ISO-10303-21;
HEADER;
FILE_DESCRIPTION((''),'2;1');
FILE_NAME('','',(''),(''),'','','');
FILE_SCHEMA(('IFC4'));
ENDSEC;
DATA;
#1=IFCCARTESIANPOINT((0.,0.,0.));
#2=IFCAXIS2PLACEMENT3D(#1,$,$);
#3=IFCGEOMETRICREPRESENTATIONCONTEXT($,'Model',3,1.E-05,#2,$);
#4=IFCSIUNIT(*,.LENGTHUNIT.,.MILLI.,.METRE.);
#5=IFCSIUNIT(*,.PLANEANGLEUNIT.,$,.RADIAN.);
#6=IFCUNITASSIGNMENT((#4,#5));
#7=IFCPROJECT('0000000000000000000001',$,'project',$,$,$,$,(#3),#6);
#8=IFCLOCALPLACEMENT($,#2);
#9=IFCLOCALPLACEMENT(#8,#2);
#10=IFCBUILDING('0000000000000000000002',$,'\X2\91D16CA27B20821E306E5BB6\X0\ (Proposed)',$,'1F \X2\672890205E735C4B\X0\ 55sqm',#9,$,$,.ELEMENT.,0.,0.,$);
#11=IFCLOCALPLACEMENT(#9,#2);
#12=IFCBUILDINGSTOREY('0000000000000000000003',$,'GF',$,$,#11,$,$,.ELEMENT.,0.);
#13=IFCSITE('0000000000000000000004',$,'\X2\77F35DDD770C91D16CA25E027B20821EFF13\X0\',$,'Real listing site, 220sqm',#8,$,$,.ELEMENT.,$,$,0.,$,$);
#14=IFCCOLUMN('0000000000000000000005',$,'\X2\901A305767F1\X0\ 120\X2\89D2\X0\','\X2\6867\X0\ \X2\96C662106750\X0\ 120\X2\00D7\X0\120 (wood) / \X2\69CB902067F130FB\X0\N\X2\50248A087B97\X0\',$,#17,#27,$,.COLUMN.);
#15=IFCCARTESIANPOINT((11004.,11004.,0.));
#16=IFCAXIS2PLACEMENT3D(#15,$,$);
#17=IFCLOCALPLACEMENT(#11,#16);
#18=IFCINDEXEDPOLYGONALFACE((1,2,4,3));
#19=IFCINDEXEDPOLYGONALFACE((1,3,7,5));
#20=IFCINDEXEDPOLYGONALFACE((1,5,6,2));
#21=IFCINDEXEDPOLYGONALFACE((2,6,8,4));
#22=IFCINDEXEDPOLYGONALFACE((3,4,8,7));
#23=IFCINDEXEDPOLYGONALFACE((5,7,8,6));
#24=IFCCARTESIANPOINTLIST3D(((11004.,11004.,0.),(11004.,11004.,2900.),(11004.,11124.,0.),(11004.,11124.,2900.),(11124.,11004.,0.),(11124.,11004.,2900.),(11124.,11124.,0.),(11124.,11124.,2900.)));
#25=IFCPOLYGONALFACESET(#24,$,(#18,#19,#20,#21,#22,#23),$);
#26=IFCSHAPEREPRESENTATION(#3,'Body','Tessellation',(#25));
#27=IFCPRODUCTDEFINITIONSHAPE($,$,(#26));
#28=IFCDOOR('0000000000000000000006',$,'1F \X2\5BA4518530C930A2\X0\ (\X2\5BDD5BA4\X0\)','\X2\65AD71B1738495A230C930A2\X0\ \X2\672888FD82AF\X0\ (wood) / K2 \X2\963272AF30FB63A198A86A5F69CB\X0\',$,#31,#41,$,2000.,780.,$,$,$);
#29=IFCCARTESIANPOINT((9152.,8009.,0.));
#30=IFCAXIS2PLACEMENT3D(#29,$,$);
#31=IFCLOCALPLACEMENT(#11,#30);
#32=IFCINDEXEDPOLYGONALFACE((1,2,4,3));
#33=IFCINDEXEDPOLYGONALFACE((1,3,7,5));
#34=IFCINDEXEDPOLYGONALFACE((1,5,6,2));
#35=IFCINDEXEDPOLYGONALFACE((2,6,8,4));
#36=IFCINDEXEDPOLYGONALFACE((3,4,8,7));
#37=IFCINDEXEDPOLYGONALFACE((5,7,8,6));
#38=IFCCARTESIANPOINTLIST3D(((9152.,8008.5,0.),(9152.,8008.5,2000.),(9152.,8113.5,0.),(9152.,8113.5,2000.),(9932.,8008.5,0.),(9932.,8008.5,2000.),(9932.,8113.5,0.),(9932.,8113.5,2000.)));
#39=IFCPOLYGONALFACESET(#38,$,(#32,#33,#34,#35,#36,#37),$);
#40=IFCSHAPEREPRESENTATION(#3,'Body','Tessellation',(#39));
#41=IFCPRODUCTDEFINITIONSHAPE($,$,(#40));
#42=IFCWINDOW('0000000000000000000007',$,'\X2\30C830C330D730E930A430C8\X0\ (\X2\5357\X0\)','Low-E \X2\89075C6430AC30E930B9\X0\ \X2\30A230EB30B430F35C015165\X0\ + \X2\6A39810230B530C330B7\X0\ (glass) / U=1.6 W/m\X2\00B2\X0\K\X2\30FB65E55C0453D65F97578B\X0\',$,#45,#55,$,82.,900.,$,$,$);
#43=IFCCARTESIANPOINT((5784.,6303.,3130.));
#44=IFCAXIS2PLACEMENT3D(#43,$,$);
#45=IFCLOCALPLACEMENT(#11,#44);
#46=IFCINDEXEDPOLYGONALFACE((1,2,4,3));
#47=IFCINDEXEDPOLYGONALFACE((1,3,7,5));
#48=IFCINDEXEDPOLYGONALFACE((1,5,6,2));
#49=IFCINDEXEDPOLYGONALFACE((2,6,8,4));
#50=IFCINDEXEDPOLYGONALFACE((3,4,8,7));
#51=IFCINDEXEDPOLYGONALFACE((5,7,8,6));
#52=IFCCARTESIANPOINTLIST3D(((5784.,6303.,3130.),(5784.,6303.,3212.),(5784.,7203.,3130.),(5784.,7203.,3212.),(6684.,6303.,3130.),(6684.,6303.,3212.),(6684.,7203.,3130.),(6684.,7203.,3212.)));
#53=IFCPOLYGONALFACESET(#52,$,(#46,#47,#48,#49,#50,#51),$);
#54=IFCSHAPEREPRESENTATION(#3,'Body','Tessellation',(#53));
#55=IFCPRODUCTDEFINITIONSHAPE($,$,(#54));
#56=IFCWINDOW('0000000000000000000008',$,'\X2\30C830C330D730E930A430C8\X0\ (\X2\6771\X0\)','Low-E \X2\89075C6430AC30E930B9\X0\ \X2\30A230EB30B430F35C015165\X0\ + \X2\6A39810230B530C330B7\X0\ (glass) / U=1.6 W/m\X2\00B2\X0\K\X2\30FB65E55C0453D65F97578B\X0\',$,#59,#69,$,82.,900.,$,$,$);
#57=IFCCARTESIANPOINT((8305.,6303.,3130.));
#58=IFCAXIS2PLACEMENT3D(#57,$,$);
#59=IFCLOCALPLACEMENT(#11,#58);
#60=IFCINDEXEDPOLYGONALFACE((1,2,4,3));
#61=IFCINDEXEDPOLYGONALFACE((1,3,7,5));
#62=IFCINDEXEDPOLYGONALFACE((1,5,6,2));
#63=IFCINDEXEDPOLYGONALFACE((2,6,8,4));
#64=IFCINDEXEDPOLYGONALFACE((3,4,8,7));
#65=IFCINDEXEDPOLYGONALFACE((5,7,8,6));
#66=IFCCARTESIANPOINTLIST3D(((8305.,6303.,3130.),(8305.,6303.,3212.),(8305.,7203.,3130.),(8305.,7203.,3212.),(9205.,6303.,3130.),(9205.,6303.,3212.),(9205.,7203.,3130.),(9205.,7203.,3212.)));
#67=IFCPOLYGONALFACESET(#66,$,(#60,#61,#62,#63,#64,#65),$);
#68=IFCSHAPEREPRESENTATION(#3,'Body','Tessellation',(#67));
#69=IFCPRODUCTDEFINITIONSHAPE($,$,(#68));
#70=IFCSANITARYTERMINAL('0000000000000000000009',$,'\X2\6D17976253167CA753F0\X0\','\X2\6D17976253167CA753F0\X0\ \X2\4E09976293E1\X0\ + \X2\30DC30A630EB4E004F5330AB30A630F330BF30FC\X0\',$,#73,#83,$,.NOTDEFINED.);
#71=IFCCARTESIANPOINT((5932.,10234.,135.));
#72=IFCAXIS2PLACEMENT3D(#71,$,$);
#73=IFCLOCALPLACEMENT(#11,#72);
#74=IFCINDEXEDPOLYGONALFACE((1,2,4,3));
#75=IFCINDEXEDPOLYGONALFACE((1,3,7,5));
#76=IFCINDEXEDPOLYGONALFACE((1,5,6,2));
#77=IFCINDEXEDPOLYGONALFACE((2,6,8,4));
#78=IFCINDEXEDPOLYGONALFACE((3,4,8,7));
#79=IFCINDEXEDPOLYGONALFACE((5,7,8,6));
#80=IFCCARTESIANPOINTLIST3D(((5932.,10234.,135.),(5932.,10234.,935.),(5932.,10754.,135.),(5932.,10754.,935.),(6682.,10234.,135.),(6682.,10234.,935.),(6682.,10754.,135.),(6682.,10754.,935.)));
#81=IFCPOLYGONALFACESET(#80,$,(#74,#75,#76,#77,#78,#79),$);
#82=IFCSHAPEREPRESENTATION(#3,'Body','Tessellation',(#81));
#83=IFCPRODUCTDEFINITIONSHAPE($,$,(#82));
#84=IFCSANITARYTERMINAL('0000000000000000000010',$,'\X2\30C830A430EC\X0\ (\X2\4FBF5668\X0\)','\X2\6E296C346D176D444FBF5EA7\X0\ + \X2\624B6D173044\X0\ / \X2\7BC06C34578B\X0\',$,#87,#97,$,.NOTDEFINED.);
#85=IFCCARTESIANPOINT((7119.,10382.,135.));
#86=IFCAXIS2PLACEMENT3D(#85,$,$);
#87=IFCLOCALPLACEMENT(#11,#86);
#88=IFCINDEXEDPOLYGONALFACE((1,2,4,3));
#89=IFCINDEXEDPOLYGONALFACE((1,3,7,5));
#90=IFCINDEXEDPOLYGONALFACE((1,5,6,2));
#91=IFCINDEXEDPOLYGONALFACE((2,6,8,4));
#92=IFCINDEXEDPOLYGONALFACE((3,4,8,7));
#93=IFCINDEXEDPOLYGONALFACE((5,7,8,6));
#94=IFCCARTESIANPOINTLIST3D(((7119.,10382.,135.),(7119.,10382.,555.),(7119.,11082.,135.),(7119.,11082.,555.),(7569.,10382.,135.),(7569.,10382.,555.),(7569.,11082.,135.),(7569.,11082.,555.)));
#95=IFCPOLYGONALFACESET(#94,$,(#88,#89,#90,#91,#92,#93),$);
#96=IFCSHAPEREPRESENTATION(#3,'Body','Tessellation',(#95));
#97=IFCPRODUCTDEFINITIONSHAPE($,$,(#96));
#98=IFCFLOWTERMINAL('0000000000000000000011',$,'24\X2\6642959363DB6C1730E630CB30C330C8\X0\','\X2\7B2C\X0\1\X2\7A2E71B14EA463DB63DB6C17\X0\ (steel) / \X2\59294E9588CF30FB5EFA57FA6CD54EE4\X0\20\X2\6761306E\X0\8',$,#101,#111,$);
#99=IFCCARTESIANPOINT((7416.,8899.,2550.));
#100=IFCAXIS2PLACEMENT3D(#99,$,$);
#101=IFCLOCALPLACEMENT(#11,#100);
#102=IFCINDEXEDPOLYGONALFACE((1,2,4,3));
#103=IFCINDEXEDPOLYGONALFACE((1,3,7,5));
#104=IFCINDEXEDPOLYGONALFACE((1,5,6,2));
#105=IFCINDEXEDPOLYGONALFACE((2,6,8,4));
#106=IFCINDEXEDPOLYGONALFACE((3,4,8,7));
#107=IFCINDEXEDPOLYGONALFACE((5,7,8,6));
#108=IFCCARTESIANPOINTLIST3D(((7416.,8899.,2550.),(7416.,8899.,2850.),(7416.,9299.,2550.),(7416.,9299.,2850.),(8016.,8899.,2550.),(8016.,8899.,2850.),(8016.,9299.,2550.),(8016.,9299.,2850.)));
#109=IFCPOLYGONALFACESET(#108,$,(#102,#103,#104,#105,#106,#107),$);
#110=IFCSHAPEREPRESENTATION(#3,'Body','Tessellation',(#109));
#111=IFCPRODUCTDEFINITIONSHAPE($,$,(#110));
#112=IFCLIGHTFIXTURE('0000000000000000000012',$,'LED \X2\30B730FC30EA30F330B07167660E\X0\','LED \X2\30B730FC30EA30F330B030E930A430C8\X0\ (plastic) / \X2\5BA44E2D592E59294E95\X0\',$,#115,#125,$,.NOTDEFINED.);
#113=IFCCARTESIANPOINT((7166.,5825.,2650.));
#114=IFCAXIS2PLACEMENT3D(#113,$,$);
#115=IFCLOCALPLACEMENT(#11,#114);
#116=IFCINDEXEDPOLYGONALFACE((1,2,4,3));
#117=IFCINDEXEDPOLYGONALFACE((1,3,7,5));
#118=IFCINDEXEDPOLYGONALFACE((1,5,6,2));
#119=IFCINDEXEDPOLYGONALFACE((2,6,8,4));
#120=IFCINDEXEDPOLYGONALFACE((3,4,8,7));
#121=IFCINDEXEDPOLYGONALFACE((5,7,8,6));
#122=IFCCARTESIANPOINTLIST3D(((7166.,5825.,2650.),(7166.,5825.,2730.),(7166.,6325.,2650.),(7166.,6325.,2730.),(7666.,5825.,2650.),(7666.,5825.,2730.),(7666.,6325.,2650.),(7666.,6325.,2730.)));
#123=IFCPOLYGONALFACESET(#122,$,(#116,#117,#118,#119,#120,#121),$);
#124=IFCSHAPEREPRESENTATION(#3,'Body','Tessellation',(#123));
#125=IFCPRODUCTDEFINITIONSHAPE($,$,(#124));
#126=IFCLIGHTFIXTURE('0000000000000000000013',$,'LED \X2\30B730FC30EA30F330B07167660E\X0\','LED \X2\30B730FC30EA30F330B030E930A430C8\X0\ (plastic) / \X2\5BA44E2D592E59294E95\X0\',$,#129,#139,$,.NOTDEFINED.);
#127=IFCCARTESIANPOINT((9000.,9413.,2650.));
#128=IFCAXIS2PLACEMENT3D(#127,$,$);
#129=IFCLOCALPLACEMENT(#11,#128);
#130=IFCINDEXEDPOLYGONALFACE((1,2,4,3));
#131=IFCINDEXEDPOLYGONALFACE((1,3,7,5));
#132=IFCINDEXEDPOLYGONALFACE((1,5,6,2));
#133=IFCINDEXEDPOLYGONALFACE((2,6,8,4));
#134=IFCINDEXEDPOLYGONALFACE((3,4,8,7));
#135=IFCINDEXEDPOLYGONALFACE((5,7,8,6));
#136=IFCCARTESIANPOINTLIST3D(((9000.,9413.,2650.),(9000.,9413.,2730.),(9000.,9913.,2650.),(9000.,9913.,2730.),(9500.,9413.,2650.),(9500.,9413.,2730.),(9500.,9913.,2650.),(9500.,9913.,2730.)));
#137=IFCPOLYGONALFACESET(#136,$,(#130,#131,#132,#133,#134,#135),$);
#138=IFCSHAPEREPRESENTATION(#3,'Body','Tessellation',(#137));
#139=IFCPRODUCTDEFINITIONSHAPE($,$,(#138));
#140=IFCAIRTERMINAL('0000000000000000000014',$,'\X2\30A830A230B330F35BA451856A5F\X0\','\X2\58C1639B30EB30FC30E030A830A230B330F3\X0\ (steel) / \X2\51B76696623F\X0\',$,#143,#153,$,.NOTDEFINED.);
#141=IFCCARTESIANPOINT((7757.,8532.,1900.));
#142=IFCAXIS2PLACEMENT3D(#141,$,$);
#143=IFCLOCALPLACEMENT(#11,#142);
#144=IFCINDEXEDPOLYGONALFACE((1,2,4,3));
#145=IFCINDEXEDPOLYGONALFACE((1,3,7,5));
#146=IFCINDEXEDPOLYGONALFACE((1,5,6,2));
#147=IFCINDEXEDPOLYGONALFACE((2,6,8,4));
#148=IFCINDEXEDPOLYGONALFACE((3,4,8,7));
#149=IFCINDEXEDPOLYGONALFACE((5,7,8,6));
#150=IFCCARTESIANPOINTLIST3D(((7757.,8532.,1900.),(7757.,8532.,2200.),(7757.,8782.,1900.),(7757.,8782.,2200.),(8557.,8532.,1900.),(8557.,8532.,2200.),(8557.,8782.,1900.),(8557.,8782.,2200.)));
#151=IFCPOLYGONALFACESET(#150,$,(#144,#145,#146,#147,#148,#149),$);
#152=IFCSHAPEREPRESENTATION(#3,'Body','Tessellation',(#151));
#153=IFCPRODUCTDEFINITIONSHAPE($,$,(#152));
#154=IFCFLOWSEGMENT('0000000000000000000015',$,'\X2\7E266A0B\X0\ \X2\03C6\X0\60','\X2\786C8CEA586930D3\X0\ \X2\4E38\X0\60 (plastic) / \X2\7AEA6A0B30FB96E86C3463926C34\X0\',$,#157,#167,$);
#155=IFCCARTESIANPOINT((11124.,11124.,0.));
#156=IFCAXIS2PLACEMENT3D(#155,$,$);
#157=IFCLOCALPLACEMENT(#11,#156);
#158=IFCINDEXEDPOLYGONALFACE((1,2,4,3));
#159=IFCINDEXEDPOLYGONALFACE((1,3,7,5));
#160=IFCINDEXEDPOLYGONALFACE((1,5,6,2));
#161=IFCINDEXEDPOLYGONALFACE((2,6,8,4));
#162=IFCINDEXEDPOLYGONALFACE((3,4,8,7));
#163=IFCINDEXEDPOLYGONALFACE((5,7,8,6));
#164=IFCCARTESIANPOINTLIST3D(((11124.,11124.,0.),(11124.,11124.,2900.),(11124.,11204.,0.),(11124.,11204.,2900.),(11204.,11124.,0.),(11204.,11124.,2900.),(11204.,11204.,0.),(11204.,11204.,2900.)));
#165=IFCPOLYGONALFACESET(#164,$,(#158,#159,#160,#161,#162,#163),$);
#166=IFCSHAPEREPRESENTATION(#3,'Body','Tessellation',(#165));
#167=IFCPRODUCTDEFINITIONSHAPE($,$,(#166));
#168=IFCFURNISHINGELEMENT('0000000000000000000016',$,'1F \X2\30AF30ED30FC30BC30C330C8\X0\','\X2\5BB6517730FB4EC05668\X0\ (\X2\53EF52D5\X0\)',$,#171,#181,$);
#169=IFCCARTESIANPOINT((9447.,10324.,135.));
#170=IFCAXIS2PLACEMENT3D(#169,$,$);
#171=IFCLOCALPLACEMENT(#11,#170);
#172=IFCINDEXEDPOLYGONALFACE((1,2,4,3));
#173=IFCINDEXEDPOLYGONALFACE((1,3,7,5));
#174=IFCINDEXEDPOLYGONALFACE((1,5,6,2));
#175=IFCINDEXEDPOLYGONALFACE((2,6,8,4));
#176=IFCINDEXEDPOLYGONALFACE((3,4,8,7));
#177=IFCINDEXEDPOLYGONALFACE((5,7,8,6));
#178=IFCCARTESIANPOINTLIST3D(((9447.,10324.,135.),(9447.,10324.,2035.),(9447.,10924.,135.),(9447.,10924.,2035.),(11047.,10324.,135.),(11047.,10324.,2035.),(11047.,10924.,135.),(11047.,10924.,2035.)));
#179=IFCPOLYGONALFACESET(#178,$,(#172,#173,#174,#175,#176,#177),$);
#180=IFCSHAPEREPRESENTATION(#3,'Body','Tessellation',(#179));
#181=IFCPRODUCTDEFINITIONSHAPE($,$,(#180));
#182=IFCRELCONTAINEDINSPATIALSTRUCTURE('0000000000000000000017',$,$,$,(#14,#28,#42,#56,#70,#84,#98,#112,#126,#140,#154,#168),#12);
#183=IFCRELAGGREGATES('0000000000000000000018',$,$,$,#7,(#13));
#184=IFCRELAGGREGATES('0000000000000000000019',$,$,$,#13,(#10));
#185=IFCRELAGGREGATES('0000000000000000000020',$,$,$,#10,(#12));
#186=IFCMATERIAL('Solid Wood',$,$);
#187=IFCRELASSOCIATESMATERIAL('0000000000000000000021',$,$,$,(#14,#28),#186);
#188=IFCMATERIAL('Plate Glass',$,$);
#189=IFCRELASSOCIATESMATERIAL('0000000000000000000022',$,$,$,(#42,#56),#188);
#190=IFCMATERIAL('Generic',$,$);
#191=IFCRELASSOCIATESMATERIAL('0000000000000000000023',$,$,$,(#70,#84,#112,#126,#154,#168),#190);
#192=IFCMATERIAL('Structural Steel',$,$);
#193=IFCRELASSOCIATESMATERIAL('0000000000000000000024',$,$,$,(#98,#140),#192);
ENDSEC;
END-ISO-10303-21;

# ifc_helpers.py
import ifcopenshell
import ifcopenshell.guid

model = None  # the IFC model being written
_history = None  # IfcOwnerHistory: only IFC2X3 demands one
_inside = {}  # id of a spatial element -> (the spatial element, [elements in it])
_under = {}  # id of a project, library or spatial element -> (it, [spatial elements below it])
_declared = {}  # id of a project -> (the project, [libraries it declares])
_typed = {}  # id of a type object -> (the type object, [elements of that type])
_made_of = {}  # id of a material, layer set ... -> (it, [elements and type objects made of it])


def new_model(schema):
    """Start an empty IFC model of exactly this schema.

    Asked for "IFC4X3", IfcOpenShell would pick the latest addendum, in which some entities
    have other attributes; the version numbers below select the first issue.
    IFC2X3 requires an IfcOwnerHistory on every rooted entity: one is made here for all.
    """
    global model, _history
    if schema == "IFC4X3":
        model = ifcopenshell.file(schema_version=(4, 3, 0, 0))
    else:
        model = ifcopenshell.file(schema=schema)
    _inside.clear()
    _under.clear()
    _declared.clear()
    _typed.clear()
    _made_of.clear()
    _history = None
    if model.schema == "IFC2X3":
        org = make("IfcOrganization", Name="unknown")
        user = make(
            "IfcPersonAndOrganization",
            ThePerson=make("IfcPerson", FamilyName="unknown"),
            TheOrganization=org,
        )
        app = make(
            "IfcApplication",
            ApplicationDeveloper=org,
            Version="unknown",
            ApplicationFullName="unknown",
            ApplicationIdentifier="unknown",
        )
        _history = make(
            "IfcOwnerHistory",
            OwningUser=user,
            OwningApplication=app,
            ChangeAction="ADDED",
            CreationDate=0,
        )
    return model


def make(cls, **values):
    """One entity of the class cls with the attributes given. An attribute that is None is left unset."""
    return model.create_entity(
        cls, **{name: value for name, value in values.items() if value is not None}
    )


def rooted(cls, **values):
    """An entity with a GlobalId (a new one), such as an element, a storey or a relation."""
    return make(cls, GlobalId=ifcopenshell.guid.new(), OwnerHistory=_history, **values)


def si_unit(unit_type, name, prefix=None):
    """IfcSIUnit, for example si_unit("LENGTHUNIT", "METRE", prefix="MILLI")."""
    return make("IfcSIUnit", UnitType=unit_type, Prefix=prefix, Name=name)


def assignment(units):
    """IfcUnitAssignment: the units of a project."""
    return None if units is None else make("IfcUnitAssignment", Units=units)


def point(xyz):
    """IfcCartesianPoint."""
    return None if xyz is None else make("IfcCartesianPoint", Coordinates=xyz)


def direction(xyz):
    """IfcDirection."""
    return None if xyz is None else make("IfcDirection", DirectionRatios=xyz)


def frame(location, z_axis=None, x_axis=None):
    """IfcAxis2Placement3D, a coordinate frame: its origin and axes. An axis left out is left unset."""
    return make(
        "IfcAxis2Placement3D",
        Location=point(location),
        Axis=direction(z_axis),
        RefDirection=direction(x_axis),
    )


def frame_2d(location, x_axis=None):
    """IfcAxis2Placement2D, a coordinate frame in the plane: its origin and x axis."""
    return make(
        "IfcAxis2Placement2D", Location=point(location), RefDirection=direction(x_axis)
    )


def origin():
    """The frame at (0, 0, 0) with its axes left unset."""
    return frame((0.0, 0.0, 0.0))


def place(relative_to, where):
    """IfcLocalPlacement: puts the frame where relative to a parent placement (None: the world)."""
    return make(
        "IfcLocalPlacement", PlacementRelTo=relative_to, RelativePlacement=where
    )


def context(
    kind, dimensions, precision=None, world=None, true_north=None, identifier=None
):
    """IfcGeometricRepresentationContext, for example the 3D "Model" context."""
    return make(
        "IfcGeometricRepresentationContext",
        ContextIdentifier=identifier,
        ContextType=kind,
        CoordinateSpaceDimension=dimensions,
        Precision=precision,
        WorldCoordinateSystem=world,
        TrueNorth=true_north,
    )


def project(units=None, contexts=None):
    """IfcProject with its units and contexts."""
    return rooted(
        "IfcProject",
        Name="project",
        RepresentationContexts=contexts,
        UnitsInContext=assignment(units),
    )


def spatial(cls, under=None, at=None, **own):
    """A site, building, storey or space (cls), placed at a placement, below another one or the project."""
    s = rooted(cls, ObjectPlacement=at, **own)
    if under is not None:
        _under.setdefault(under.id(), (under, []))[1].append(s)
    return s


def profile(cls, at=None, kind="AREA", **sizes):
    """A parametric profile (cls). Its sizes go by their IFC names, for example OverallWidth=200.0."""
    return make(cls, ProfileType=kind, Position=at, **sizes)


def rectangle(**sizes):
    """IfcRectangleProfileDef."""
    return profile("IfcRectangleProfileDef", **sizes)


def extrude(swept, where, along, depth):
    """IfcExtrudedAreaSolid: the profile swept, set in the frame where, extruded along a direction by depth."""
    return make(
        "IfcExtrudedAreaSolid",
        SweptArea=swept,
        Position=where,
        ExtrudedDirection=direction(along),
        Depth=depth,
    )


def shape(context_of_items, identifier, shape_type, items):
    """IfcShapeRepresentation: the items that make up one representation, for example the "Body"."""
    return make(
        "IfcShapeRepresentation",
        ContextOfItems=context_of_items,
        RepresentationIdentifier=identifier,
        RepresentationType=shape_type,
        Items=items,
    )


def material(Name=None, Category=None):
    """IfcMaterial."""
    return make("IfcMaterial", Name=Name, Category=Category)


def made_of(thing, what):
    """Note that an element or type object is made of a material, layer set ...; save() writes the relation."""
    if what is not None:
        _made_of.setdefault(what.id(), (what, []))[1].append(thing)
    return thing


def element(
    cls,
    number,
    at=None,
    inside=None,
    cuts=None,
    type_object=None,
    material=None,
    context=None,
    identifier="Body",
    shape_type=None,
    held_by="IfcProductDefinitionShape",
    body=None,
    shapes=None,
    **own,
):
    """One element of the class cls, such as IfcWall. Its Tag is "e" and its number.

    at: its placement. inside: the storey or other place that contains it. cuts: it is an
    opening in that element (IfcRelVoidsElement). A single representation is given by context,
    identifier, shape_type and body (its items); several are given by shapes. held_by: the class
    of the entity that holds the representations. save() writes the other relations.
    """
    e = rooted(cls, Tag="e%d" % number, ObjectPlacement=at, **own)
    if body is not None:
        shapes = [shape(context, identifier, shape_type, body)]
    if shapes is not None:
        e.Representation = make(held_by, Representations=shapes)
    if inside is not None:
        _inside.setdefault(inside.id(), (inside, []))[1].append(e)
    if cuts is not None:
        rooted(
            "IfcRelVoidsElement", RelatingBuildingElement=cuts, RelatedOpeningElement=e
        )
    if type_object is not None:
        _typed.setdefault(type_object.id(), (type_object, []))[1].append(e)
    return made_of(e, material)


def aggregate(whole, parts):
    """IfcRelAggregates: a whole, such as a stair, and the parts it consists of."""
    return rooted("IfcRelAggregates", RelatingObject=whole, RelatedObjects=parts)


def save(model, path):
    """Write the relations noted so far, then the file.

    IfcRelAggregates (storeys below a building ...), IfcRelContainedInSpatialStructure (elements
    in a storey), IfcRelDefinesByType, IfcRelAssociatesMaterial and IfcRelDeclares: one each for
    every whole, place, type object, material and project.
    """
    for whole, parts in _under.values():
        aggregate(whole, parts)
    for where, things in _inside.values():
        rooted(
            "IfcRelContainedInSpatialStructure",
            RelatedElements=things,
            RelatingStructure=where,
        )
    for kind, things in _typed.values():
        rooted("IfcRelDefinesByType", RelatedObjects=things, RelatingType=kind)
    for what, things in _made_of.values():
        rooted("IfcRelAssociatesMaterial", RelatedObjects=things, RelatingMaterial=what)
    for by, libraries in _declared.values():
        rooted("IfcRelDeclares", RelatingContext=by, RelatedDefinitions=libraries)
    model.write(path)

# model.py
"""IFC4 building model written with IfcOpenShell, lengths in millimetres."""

from ifc_helpers import new_model, si_unit, frame, frame_2d, origin, place, context, project, spatial, rectangle, extrude, material, element, save


model = new_model("IFC4")

# Units and contexts
model_context = context("Model", 3, precision=1e-05, world=origin())
ifc_project = project(units=[si_unit("LENGTHUNIT", "METRE", prefix="MILLI"), si_unit("PLANEANGLEUNIT", "RADIAN")], contexts=[model_context])

# Site, building, storey
site_placement = place(None, origin())
site = spatial("IfcSite", under=ifc_project, at=site_placement, Name="石川県金沢市笠舞３", ObjectType="Real listing site, 220sqm", CompositionType="ELEMENT", RefElevation=0.0)
building_placement = place(site_placement, origin())
building = spatial("IfcBuilding", under=site, at=building_placement, Name="金沢笠舞の家 (Proposed)", ObjectType="1F 木造平屋 55sqm", CompositionType="ELEMENT", ElevationOfRefHeight=0.0, ElevationOfTerrain=0.0)
storey_placement = place(building_placement, origin())
storey = spatial("IfcBuildingStorey", under=building, at=storey_placement, Name="GF", CompositionType="ELEMENT", Elevation=0.0)

# Column
ifc_material_1 = material(Name="Solid Wood")
column_1_placement = place(storey_placement, frame((11004.0, 11004.0, 0.0)))
element("IfcColumn", 1, at=column_1_placement, inside=storey, material=ifc_material_1, Name="通し柱 120角", Description="桧 集成材 120×120 (wood) / 構造柱・N値計算", PredefinedType="COLUMN", context=model_context, shape_type="SweptSolid", body=[
    extrude(rectangle(XDim=120.0, YDim=120.0, at=frame_2d((60.0, 60.0))), frame((11004.0, 11004.0, 0.0)), (0.0, 0.0, 1.0), 2900.0),
])

# Door
door_placement = place(storey_placement, frame((9152.0, 8009.0, 0.0)))
element("IfcDoor", 2, at=door_placement, inside=storey, material=ifc_material_1, Name="1F 室内ドア (寝室)", Description="断熱玄関ドア 木製芯 (wood) / K2 防犯・採風機構", OverallHeight=2000.0, OverallWidth=780.0, context=model_context, shape_type="SweptSolid", body=[
    extrude(rectangle(XDim=780.0, YDim=105.0, at=frame_2d((390.0, 52.0))), frame((9152.0, 8009.0, 0.0)), (0.0, 0.0, 1.0), 2000.0),
])

# Windows
ifc_material_2 = material(Name="Plate Glass")
window_1_placement = place(storey_placement, frame((5784.0, 6303.0, 3130.0)))
element("IfcWindow", 3, at=window_1_placement, inside=storey, material=ifc_material_2, Name="トップライト (南)", Description="Low-E 複層ガラス アルゴン封入 + 樹脂サッシ (glass) / U=1.6 W/m²K・日射取得型", OverallHeight=82.0, OverallWidth=900.0, context=model_context, shape_type="SweptSolid", body=[
    extrude(rectangle(XDim=900.0, YDim=900.0, at=frame_2d((450.0, 450.0))), frame((5784.0, 6303.0, 3130.0)), (0.0, 0.0, 1.0), 82.0),
])
window_2_placement = place(storey_placement, frame((8305.0, 6303.0, 3130.0)))
element("IfcWindow", 4, at=window_2_placement, inside=storey, material=ifc_material_2, Name="トップライト (東)", Description="Low-E 複層ガラス アルゴン封入 + 樹脂サッシ (glass) / U=1.6 W/m²K・日射取得型", OverallHeight=82.0, OverallWidth=900.0, context=model_context, shape_type="SweptSolid", body=[
    extrude(rectangle(XDim=900.0, YDim=900.0, at=frame_2d((450.0, 450.0))), frame((8305.0, 6303.0, 3130.0)), (0.0, 0.0, 1.0), 82.0),
])

# Sanitary terminals
ifc_material_3 = material(Name="Generic")
sanitary_terminal_1_placement = place(storey_placement, frame((5932.0, 10234.0, 135.0)))
element("IfcSanitaryTerminal", 5, at=sanitary_terminal_1_placement, inside=storey, material=ifc_material_3, Name="洗面化粧台", Description="洗面化粧台 三面鏡 + ボウル一体カウンター", PredefinedType="NOTDEFINED", context=model_context, shape_type="SweptSolid", body=[
    extrude(rectangle(XDim=750.0, YDim=520.0, at=frame_2d((375.0, 260.0))), frame((5932.0, 10234.0, 135.0)), (0.0, 0.0, 1.0), 800.0),
])
sanitary_terminal_2_placement = place(storey_placement, frame((7119.0, 10382.0, 135.0)))
element("IfcSanitaryTerminal", 6, at=sanitary_terminal_2_placement, inside=storey, material=ifc_material_3, Name="トイレ (便器)", Description="温水洗浄便座 + 手洗い / 節水型", PredefinedType="NOTDEFINED", context=model_context, shape_type="SweptSolid", body=[
    extrude(rectangle(XDim=450.0, YDim=700.0, at=frame_2d((225.0, 350.0))), frame((7119.0, 10382.0, 135.0)), (0.0, 0.0, 1.0), 420.0),
])

# Flow terminal
ifc_material_4 = material(Name="Structural Steel")
flow_terminal_placement = place(storey_placement, frame((7416.0, 8899.0, 2550.0)))
element("IfcFlowTerminal", 7, at=flow_terminal_placement, inside=storey, material=ifc_material_4, Name="24時間換気ユニット", Description="第1種熱交換換気 (steel) / 天井裏・建基法令20条の8", context=model_context, shape_type="SweptSolid", body=[
    extrude(rectangle(XDim=600.0, YDim=400.0, at=frame_2d((300.0, 200.0))), frame((7416.0, 8899.0, 2550.0)), (0.0, 0.0, 1.0), 300.0),
])

# Light fixtures
light_fixture_1_placement = place(storey_placement, frame((7166.0, 5825.0, 2650.0)))
element("IfcLightFixture", 8, at=light_fixture_1_placement, inside=storey, material=ifc_material_3, Name="LED シーリング照明", Description="LED シーリングライト (plastic) / 室中央天井", PredefinedType="NOTDEFINED", context=model_context, shape_type="SweptSolid", body=[
    extrude(rectangle(XDim=500.0, YDim=500.0, at=frame_2d((250.0, 250.0))), frame((7166.0, 5825.0, 2650.0)), (0.0, 0.0, 1.0), 80.0),
])
light_fixture_2_placement = place(storey_placement, frame((9000.0, 9413.0, 2650.0)))
element("IfcLightFixture", 9, at=light_fixture_2_placement, inside=storey, material=ifc_material_3, Name="LED シーリング照明", Description="LED シーリングライト (plastic) / 室中央天井", PredefinedType="NOTDEFINED", context=model_context, shape_type="SweptSolid", body=[
    extrude(rectangle(XDim=500.0, YDim=500.0, at=frame_2d((250.0, 250.0))), frame((9000.0, 9413.0, 2650.0)), (0.0, 0.0, 1.0), 80.0),
])

# Air terminal
air_terminal_placement = place(storey_placement, frame((7757.0, 8532.0, 1900.0)))
element("IfcAirTerminal", 10, at=air_terminal_placement, inside=storey, material=ifc_material_4, Name="エアコン室内機", Description="壁掛ルームエアコン (steel) / 冷暖房", PredefinedType="NOTDEFINED", context=model_context, shape_type="SweptSolid", body=[
    extrude(rectangle(XDim=800.0, YDim=250.0, at=frame_2d((400.0, 125.0))), frame((7757.0, 8532.0, 1900.0)), (0.0, 0.0, 1.0), 300.0),
])

# Flow segment
flow_segment_placement = place(storey_placement, frame((11124.0, 11124.0, 0.0)))
element("IfcFlowSegment", 11, at=flow_segment_placement, inside=storey, material=ifc_material_3, Name="縦樋 φ60", Description="硬質塩ビ 丸60 (plastic) / 竪樋・雨水排水", context=model_context, shape_type="SweptSolid", body=[
    extrude(rectangle(XDim=80.0, YDim=80.0, at=frame_2d((40.0, 40.0))), frame((11124.0, 11124.0, 0.0)), (0.0, 0.0, 1.0), 2900.0),
])

# Furnishing element
furnishing_placement = place(storey_placement, frame((9447.0, 10324.0, 135.0)))
element("IfcFurnishingElement", 12, at=furnishing_placement, inside=storey, material=ifc_material_3, Name="1F クローゼット", Description="家具・什器 (可動)", context=model_context, shape_type="SweptSolid", body=[
    extrude(rectangle(XDim=1600.0, YDim=600.0, at=frame_2d((800.0, 300.0))), frame((9447.0, 10324.0, 135.0)), (0.0, 0.0, 1.0), 1900.0),
])

save(model, "model.ifc")
